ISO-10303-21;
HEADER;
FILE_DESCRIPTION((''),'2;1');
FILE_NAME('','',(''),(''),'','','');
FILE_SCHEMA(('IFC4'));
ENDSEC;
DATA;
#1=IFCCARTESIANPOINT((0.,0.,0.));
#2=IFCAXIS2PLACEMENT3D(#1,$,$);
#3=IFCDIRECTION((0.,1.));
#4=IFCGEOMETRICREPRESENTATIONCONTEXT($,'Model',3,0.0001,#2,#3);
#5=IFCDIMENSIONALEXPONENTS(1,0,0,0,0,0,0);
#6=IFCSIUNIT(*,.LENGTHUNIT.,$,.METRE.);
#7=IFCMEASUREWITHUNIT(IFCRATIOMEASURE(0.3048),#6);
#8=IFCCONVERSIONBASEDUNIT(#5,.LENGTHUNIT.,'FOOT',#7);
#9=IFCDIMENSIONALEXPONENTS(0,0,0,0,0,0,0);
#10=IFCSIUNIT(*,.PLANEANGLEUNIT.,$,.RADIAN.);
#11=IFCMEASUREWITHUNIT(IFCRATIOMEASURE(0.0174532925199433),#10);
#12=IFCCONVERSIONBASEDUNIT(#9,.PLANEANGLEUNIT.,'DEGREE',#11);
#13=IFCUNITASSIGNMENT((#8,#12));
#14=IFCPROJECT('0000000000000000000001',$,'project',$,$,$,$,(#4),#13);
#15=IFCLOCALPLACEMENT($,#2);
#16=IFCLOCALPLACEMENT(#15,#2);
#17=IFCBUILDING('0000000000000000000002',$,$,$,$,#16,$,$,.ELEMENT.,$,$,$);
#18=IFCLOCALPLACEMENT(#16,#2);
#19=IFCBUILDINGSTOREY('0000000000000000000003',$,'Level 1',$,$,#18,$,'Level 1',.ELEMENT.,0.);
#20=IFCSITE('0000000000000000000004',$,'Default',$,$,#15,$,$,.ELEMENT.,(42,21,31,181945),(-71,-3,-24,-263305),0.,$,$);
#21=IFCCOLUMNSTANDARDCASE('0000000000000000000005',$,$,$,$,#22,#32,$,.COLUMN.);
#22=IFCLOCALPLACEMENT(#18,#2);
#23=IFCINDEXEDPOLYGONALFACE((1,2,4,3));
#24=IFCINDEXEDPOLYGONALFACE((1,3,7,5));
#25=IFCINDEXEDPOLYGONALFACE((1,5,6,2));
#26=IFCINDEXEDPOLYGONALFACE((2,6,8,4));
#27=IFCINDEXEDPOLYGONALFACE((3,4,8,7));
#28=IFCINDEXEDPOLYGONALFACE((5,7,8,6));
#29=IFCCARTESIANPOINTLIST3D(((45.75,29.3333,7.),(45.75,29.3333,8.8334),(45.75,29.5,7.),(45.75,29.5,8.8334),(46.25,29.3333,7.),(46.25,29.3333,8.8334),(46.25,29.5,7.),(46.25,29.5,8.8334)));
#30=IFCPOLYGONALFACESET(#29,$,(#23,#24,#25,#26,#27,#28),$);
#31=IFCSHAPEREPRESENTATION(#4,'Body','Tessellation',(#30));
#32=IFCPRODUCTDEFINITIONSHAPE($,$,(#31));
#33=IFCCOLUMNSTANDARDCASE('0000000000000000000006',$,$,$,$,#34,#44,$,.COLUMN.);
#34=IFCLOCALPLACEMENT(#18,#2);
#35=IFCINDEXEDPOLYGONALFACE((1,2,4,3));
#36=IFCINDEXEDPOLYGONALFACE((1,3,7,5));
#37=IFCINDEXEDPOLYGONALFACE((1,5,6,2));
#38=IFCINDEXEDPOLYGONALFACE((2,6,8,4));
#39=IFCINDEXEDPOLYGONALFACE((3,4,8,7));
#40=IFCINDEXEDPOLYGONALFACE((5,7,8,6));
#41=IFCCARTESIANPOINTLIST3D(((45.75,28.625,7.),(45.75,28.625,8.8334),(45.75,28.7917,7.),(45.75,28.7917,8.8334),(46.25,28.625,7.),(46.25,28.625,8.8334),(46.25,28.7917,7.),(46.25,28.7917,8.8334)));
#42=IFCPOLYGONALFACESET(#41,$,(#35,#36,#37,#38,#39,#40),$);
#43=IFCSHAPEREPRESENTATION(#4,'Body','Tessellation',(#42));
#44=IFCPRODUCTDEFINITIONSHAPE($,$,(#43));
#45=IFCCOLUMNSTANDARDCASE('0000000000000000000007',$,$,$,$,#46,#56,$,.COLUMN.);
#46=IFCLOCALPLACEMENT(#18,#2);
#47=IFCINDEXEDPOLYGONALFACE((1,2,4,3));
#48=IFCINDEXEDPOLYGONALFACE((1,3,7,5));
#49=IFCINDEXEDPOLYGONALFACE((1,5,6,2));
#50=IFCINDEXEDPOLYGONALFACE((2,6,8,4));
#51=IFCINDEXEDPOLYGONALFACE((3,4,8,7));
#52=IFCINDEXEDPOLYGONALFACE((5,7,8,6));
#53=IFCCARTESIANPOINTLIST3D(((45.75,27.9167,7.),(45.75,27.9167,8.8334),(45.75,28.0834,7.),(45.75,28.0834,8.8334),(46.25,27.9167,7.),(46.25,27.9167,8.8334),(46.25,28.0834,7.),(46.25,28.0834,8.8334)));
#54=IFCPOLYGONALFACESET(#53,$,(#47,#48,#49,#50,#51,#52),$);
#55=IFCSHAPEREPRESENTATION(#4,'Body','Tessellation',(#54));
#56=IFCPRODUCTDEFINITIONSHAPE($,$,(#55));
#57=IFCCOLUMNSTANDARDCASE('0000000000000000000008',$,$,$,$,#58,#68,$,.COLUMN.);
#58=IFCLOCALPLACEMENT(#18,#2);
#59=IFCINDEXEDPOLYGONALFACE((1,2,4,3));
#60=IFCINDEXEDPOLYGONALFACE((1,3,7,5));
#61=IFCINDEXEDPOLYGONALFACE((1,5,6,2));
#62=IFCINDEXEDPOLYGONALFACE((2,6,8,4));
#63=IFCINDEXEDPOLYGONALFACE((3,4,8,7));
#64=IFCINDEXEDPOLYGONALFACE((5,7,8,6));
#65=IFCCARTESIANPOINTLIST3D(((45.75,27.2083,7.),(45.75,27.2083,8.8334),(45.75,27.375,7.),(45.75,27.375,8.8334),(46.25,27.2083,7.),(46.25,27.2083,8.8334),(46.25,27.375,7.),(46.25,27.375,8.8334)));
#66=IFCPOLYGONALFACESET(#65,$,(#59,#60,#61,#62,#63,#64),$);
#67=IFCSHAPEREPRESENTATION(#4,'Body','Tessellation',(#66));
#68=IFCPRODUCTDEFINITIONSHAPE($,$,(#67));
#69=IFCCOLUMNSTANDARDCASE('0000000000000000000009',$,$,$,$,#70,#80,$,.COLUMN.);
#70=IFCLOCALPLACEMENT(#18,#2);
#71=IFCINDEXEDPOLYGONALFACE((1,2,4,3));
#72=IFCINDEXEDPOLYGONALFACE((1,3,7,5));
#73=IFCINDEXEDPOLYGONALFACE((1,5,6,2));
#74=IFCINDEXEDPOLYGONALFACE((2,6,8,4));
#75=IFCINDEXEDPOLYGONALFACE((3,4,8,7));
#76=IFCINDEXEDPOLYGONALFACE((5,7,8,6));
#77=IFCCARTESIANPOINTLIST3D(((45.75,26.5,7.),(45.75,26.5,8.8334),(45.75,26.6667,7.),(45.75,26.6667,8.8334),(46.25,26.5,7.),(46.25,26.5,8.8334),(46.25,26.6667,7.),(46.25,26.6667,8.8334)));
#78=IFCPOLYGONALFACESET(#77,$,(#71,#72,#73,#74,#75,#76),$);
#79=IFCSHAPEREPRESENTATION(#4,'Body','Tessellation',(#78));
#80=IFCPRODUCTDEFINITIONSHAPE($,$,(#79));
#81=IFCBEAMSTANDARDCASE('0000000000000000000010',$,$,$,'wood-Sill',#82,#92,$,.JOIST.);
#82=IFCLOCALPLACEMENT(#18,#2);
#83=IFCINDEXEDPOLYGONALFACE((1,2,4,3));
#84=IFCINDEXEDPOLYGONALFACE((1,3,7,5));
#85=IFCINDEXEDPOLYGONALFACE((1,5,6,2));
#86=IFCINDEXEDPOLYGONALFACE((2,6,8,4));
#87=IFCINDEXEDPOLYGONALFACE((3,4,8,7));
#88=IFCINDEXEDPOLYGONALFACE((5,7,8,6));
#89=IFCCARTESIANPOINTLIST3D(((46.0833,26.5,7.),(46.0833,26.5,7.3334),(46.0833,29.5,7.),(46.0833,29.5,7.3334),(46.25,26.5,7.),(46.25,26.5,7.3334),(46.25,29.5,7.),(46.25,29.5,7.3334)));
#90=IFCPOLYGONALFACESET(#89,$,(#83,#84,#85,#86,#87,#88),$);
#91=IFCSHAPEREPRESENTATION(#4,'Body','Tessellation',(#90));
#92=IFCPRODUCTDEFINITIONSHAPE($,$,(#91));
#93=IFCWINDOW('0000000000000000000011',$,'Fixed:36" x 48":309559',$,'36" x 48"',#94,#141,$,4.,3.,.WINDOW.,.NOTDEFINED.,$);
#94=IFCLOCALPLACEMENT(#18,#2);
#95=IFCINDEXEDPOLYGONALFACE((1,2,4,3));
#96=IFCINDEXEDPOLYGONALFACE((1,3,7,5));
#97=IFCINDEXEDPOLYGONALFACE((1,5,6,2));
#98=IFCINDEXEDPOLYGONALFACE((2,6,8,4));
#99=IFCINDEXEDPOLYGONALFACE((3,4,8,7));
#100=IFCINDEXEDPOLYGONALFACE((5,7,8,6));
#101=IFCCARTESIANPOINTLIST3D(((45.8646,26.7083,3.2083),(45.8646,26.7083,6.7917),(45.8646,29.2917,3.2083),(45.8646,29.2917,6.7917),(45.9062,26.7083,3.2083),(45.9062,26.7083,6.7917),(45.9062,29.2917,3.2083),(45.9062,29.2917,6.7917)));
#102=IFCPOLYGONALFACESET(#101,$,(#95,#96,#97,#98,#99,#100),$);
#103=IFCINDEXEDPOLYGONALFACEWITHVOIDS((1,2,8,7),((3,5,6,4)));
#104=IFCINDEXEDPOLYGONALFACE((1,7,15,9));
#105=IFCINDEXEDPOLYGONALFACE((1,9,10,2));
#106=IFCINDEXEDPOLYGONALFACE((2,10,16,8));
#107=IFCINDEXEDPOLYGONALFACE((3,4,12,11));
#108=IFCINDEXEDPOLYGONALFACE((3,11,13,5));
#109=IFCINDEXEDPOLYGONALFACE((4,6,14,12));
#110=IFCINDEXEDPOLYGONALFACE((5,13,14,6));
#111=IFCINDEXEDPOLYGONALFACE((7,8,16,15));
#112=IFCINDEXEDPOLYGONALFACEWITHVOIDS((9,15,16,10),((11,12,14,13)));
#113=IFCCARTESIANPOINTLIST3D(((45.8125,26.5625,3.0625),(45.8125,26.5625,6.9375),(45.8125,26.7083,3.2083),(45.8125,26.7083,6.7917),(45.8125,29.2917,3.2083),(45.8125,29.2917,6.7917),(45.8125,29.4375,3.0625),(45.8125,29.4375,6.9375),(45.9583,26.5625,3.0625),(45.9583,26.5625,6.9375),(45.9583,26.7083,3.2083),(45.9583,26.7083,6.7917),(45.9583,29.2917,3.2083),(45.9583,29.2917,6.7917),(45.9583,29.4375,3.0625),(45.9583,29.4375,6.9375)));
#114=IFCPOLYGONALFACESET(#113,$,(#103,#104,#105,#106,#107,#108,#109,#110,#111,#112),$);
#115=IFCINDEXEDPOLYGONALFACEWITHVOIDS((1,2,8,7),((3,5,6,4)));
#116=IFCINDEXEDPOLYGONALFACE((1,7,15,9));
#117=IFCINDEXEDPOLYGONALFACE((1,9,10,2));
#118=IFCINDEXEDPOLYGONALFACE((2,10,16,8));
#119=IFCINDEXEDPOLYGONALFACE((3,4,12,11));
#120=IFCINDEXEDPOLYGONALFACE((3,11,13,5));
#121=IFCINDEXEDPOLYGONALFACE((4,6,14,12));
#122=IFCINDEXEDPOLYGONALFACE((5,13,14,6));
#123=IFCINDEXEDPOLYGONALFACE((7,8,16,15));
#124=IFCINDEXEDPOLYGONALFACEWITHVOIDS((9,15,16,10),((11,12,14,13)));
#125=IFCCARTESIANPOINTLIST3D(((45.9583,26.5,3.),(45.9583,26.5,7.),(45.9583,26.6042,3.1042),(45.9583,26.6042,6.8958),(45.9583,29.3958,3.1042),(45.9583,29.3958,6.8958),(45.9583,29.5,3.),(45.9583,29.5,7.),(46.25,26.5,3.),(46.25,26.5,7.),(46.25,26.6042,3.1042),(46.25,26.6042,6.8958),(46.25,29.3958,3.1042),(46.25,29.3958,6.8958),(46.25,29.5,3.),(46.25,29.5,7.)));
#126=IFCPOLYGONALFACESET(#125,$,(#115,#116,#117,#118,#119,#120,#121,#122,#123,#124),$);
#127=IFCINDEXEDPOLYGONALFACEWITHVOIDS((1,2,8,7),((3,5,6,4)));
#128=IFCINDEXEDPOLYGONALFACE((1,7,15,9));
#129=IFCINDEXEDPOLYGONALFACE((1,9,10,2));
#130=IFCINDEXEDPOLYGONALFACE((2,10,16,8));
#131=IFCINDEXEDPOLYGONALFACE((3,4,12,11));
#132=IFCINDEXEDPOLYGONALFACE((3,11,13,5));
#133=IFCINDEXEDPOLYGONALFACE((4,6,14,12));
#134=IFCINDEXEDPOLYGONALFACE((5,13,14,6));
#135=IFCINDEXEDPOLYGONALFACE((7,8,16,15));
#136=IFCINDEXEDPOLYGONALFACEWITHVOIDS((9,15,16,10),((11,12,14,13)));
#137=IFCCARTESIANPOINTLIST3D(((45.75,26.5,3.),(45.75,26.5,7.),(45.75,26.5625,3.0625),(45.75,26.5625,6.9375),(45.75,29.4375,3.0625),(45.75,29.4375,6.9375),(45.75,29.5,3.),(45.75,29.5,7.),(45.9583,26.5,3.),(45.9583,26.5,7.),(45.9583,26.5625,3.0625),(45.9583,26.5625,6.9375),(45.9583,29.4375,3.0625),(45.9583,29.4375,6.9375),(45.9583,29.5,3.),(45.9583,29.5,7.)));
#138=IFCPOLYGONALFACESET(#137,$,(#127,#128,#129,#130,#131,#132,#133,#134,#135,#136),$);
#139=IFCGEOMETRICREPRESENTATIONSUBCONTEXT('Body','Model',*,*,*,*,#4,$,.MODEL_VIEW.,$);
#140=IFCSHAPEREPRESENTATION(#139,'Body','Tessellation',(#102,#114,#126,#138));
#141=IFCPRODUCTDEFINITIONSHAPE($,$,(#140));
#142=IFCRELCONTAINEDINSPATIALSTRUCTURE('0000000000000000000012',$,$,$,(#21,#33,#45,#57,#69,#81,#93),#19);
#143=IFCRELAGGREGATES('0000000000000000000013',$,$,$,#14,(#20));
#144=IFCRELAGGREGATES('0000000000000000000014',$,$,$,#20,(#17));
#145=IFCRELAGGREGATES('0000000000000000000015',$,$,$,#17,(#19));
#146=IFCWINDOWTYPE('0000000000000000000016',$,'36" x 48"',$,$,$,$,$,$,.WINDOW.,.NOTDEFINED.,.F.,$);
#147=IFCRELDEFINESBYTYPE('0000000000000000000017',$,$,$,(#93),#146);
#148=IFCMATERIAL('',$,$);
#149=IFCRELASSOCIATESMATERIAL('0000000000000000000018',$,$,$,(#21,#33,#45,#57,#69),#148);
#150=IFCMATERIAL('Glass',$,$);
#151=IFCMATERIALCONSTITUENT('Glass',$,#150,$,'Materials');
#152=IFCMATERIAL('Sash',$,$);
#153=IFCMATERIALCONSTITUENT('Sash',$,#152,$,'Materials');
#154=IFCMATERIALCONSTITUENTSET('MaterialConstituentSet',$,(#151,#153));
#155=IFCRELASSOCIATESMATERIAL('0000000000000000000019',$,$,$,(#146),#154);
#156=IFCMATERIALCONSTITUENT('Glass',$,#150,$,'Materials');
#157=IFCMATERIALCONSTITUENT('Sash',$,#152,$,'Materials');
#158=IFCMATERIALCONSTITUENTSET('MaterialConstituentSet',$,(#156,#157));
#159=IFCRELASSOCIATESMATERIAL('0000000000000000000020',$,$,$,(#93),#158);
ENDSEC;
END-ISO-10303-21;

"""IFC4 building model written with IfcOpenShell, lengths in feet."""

from ifc_helpers import new_model, entity, si_unit, converted_unit, direction, frame, frame_2d, origin, origin_with_axes, place, context, subcontext, project, spatial, polyline, rectangle, outline, extrude, source, transform, mapped, material, constituent, constituent_set, type_object, type_shapes, element, save


model = new_model("IFC4")

# Units and contexts
model_context = context("Model", 3, precision=0.0001, world=origin(), true_north=direction((0.0, 1.0)))
body_context = subcontext(model_context, "Body", "Model", "MODEL_VIEW")
ifc_project = project(units=[converted_unit("LENGTHUNIT", "FOOT", entity("IfcRatioMeasure", 0.3048), si_unit("LENGTHUNIT", "METRE"), dimensions=[1, 0, 0, 0, 0, 0, 0]), converted_unit("PLANEANGLEUNIT", "DEGREE", entity("IfcRatioMeasure", 0.0174532925199433), si_unit("PLANEANGLEUNIT", "RADIAN"), dimensions=[0, 0, 0, 0, 0, 0, 0])], contexts=[model_context])

# Site, building, storey
site_placement = place(None, origin())
site = spatial("IfcSite", under=ifc_project, at=site_placement, Name="Default", CompositionType="ELEMENT", RefLatitude=(42, 21, 31, 181945), RefLongitude=(-71, -3, -24, -263305), RefElevation=0.0)
building_placement = place(site_placement, origin())
building = spatial("IfcBuilding", under=site, at=building_placement, CompositionType="ELEMENT")
storey_placement = place(building_placement, origin())
storey = spatial("IfcBuildingStorey", under=building, at=storey_placement, Name="Level 1", LongName="Level 1", CompositionType="ELEMENT", Elevation=0.0)

# Columns
placement_1 = place(storey_placement, frame((46.0, 46.25, 0.0), z_axis=(0.0, 0.0, 1.0), x_axis=(0.0, -1.0, 0.0)))
ifc_material_1 = material(Name="")
for number, where, z_axis, x_axis in (
    (1, (16.8334, 0.0, 7.0), (0.0, 0.0, 1.0), (1.0, 0.0, 0.0)),
    (2, (17.5417, 0.0, 7.0), (0.0, 0.0, 1.0), (1.0, 0.0, 0.0)),
    (3, (18.25, 0.0, 7.0), (0.0, 0.0, 1.0), (1.0, 0.0, 0.0)),
    (4, (18.9584, 0.0, 7.0), (0.0, 0.0, 1.0), (1.0, 0.0, 0.0)),
    (5, (19.6667, 0.0, 7.0), (0.0, 0.0, 1.0), (1.0, 0.0, 0.0)),
):
    element("IfcColumnStandardCase", number, at=place(placement_1, frame(where, z_axis=z_axis, x_axis=x_axis)), inside=storey, material=ifc_material_1, PredefinedType="COLUMN", context=model_context, shape_type="SweptSolid", body=[
        extrude(rectangle(XDim=0.1667, YDim=0.5), origin(), (0.0, 0.0, 1.0), 1.8334),
    ])

# Beam
for number, where, z_axis, x_axis in (
    (6, (16.75, 0.1667, 7.1667), (1.0, 0.0, 0.0), (0.0, 0.0, 1.0)),
):
    element("IfcBeamStandardCase", number, at=place(placement_1, frame(where, z_axis=z_axis, x_axis=x_axis)), inside=storey, ObjectType="wood-Sill", PredefinedType="JOIST", context=model_context, shape_type="SweptSolid", body=[
        extrude(rectangle(XDim=0.3333, YDim=0.1667), origin_with_axes(), (0.0, 0.0, 1.0), 3.0),
    ])

# Window
ifc_material_2 = material(Name="Glass")
ifc_constituent_1 = constituent(ifc_material_2, Name="Glass", Category="Materials")
ifc_material_3 = material(Name="Sash")
ifc_constituent_2 = constituent(ifc_material_3, Name="Sash", Category="Materials")
ifc_constituent_set_1 = constituent_set(constituents=[ifc_constituent_1, ifc_constituent_2], Name="MaterialConstituentSet")
ifc_constituent_3 = constituent(ifc_material_2, Name="Glass", Category="Materials")
ifc_constituent_4 = constituent(ifc_material_3, Name="Sash", Category="Materials")
ifc_constituent_set_2 = constituent_set(constituents=[ifc_constituent_3, ifc_constituent_4], Name="MaterialConstituentSet")
window_type = type_object("IfcWindowType", Name="36\" x 48\"", ParameterTakesPrecedence=False, PartitioningType="NOTDEFINED", PredefinedType="WINDOW", material=ifc_constituent_set_2)
shared_shape = source(origin(), body_context, "Body", "SweptSolid", [
    extrude(rectangle(XDim=0.0417, YDim=2.5833, at=frame_2d((0.0, 0.0), x_axis=(1.0, 0.0))), frame((1.5, 0.3646, 0.2083), z_axis=(0.0, 0.0, 1.0), x_axis=(0.0, 1.0, 0.0)), (0.0, 0.0, 1.0), 3.5833),
    extrude(outline(polyline([(-1.4375, -1.9375), (1.4375, -1.9375), (1.4375, 1.9375), (-1.4375, 1.9375), (-1.4375, -1.9375)]), holes=[polyline([(-1.2917, -1.7917), (-1.2917, 1.7917), (1.2917, 1.7917), (1.2917, -1.7917), (-1.2917, -1.7917)])]), frame((1.5, 0.2917, 2.0), z_axis=(0.0, 1.0, 0.0), x_axis=(1.0, 0.0, 0.0)), (0.0, 0.0, 1.0), 0.1458),
    extrude(outline(polyline([(-1.5, -2.0), (1.5, -2.0), (1.5, 2.0), (-1.5, 2.0), (-1.5, -2.0)]), holes=[polyline([(-1.3958, -1.8958), (-1.3958, 1.8958), (1.3958, 1.8958), (1.3958, -1.8958), (-1.3958, -1.8958)])]), frame((1.5, 0.0, 2.0), z_axis=(0.0, 1.0, 0.0), x_axis=(1.0, 0.0, 0.0)), (0.0, 0.0, 1.0), 0.2917),
    extrude(outline(polyline([(-2.0, -1.5), (2.0, -1.5), (2.0, 1.5), (-2.0, 1.5), (-2.0, -1.5)]), holes=[polyline([(-1.9375, -1.4375), (-1.9375, 1.4375), (1.9375, 1.4375), (1.9375, -1.4375), (-1.9375, -1.4375)])]), frame((1.5, 0.2917, 2.0), z_axis=(0.0, 1.0, 0.0), x_axis=(0.0, 0.0, -1.0)), (0.0, 0.0, 1.0), 0.2083),
])
type_shapes(window_type, [shared_shape])
placement_2 = place(placement_1, frame((19.75, 0.25, 3.0)))
window_placement = place(placement_2, frame((0.0, 0.0, 0.0), z_axis=(0.0, 0.0, 1.0), x_axis=(-1.0, 0.0, 0.0)))
element("IfcWindow", 7, at=window_placement, inside=storey, type_object=window_type, material=ifc_constituent_set_1, Name="Fixed:36\" x 48\":309559", ObjectType="36\" x 48\"", OverallHeight=4.0, OverallWidth=3.0, PartitioningType="NOTDEFINED", PredefinedType="WINDOW", context=body_context, shape_type="MappedRepresentation", body=[
    mapped(shared_shape, transform((0.0, 0.0, 0.0), scale=1.0)),
])

save(model, "model.ifc")
